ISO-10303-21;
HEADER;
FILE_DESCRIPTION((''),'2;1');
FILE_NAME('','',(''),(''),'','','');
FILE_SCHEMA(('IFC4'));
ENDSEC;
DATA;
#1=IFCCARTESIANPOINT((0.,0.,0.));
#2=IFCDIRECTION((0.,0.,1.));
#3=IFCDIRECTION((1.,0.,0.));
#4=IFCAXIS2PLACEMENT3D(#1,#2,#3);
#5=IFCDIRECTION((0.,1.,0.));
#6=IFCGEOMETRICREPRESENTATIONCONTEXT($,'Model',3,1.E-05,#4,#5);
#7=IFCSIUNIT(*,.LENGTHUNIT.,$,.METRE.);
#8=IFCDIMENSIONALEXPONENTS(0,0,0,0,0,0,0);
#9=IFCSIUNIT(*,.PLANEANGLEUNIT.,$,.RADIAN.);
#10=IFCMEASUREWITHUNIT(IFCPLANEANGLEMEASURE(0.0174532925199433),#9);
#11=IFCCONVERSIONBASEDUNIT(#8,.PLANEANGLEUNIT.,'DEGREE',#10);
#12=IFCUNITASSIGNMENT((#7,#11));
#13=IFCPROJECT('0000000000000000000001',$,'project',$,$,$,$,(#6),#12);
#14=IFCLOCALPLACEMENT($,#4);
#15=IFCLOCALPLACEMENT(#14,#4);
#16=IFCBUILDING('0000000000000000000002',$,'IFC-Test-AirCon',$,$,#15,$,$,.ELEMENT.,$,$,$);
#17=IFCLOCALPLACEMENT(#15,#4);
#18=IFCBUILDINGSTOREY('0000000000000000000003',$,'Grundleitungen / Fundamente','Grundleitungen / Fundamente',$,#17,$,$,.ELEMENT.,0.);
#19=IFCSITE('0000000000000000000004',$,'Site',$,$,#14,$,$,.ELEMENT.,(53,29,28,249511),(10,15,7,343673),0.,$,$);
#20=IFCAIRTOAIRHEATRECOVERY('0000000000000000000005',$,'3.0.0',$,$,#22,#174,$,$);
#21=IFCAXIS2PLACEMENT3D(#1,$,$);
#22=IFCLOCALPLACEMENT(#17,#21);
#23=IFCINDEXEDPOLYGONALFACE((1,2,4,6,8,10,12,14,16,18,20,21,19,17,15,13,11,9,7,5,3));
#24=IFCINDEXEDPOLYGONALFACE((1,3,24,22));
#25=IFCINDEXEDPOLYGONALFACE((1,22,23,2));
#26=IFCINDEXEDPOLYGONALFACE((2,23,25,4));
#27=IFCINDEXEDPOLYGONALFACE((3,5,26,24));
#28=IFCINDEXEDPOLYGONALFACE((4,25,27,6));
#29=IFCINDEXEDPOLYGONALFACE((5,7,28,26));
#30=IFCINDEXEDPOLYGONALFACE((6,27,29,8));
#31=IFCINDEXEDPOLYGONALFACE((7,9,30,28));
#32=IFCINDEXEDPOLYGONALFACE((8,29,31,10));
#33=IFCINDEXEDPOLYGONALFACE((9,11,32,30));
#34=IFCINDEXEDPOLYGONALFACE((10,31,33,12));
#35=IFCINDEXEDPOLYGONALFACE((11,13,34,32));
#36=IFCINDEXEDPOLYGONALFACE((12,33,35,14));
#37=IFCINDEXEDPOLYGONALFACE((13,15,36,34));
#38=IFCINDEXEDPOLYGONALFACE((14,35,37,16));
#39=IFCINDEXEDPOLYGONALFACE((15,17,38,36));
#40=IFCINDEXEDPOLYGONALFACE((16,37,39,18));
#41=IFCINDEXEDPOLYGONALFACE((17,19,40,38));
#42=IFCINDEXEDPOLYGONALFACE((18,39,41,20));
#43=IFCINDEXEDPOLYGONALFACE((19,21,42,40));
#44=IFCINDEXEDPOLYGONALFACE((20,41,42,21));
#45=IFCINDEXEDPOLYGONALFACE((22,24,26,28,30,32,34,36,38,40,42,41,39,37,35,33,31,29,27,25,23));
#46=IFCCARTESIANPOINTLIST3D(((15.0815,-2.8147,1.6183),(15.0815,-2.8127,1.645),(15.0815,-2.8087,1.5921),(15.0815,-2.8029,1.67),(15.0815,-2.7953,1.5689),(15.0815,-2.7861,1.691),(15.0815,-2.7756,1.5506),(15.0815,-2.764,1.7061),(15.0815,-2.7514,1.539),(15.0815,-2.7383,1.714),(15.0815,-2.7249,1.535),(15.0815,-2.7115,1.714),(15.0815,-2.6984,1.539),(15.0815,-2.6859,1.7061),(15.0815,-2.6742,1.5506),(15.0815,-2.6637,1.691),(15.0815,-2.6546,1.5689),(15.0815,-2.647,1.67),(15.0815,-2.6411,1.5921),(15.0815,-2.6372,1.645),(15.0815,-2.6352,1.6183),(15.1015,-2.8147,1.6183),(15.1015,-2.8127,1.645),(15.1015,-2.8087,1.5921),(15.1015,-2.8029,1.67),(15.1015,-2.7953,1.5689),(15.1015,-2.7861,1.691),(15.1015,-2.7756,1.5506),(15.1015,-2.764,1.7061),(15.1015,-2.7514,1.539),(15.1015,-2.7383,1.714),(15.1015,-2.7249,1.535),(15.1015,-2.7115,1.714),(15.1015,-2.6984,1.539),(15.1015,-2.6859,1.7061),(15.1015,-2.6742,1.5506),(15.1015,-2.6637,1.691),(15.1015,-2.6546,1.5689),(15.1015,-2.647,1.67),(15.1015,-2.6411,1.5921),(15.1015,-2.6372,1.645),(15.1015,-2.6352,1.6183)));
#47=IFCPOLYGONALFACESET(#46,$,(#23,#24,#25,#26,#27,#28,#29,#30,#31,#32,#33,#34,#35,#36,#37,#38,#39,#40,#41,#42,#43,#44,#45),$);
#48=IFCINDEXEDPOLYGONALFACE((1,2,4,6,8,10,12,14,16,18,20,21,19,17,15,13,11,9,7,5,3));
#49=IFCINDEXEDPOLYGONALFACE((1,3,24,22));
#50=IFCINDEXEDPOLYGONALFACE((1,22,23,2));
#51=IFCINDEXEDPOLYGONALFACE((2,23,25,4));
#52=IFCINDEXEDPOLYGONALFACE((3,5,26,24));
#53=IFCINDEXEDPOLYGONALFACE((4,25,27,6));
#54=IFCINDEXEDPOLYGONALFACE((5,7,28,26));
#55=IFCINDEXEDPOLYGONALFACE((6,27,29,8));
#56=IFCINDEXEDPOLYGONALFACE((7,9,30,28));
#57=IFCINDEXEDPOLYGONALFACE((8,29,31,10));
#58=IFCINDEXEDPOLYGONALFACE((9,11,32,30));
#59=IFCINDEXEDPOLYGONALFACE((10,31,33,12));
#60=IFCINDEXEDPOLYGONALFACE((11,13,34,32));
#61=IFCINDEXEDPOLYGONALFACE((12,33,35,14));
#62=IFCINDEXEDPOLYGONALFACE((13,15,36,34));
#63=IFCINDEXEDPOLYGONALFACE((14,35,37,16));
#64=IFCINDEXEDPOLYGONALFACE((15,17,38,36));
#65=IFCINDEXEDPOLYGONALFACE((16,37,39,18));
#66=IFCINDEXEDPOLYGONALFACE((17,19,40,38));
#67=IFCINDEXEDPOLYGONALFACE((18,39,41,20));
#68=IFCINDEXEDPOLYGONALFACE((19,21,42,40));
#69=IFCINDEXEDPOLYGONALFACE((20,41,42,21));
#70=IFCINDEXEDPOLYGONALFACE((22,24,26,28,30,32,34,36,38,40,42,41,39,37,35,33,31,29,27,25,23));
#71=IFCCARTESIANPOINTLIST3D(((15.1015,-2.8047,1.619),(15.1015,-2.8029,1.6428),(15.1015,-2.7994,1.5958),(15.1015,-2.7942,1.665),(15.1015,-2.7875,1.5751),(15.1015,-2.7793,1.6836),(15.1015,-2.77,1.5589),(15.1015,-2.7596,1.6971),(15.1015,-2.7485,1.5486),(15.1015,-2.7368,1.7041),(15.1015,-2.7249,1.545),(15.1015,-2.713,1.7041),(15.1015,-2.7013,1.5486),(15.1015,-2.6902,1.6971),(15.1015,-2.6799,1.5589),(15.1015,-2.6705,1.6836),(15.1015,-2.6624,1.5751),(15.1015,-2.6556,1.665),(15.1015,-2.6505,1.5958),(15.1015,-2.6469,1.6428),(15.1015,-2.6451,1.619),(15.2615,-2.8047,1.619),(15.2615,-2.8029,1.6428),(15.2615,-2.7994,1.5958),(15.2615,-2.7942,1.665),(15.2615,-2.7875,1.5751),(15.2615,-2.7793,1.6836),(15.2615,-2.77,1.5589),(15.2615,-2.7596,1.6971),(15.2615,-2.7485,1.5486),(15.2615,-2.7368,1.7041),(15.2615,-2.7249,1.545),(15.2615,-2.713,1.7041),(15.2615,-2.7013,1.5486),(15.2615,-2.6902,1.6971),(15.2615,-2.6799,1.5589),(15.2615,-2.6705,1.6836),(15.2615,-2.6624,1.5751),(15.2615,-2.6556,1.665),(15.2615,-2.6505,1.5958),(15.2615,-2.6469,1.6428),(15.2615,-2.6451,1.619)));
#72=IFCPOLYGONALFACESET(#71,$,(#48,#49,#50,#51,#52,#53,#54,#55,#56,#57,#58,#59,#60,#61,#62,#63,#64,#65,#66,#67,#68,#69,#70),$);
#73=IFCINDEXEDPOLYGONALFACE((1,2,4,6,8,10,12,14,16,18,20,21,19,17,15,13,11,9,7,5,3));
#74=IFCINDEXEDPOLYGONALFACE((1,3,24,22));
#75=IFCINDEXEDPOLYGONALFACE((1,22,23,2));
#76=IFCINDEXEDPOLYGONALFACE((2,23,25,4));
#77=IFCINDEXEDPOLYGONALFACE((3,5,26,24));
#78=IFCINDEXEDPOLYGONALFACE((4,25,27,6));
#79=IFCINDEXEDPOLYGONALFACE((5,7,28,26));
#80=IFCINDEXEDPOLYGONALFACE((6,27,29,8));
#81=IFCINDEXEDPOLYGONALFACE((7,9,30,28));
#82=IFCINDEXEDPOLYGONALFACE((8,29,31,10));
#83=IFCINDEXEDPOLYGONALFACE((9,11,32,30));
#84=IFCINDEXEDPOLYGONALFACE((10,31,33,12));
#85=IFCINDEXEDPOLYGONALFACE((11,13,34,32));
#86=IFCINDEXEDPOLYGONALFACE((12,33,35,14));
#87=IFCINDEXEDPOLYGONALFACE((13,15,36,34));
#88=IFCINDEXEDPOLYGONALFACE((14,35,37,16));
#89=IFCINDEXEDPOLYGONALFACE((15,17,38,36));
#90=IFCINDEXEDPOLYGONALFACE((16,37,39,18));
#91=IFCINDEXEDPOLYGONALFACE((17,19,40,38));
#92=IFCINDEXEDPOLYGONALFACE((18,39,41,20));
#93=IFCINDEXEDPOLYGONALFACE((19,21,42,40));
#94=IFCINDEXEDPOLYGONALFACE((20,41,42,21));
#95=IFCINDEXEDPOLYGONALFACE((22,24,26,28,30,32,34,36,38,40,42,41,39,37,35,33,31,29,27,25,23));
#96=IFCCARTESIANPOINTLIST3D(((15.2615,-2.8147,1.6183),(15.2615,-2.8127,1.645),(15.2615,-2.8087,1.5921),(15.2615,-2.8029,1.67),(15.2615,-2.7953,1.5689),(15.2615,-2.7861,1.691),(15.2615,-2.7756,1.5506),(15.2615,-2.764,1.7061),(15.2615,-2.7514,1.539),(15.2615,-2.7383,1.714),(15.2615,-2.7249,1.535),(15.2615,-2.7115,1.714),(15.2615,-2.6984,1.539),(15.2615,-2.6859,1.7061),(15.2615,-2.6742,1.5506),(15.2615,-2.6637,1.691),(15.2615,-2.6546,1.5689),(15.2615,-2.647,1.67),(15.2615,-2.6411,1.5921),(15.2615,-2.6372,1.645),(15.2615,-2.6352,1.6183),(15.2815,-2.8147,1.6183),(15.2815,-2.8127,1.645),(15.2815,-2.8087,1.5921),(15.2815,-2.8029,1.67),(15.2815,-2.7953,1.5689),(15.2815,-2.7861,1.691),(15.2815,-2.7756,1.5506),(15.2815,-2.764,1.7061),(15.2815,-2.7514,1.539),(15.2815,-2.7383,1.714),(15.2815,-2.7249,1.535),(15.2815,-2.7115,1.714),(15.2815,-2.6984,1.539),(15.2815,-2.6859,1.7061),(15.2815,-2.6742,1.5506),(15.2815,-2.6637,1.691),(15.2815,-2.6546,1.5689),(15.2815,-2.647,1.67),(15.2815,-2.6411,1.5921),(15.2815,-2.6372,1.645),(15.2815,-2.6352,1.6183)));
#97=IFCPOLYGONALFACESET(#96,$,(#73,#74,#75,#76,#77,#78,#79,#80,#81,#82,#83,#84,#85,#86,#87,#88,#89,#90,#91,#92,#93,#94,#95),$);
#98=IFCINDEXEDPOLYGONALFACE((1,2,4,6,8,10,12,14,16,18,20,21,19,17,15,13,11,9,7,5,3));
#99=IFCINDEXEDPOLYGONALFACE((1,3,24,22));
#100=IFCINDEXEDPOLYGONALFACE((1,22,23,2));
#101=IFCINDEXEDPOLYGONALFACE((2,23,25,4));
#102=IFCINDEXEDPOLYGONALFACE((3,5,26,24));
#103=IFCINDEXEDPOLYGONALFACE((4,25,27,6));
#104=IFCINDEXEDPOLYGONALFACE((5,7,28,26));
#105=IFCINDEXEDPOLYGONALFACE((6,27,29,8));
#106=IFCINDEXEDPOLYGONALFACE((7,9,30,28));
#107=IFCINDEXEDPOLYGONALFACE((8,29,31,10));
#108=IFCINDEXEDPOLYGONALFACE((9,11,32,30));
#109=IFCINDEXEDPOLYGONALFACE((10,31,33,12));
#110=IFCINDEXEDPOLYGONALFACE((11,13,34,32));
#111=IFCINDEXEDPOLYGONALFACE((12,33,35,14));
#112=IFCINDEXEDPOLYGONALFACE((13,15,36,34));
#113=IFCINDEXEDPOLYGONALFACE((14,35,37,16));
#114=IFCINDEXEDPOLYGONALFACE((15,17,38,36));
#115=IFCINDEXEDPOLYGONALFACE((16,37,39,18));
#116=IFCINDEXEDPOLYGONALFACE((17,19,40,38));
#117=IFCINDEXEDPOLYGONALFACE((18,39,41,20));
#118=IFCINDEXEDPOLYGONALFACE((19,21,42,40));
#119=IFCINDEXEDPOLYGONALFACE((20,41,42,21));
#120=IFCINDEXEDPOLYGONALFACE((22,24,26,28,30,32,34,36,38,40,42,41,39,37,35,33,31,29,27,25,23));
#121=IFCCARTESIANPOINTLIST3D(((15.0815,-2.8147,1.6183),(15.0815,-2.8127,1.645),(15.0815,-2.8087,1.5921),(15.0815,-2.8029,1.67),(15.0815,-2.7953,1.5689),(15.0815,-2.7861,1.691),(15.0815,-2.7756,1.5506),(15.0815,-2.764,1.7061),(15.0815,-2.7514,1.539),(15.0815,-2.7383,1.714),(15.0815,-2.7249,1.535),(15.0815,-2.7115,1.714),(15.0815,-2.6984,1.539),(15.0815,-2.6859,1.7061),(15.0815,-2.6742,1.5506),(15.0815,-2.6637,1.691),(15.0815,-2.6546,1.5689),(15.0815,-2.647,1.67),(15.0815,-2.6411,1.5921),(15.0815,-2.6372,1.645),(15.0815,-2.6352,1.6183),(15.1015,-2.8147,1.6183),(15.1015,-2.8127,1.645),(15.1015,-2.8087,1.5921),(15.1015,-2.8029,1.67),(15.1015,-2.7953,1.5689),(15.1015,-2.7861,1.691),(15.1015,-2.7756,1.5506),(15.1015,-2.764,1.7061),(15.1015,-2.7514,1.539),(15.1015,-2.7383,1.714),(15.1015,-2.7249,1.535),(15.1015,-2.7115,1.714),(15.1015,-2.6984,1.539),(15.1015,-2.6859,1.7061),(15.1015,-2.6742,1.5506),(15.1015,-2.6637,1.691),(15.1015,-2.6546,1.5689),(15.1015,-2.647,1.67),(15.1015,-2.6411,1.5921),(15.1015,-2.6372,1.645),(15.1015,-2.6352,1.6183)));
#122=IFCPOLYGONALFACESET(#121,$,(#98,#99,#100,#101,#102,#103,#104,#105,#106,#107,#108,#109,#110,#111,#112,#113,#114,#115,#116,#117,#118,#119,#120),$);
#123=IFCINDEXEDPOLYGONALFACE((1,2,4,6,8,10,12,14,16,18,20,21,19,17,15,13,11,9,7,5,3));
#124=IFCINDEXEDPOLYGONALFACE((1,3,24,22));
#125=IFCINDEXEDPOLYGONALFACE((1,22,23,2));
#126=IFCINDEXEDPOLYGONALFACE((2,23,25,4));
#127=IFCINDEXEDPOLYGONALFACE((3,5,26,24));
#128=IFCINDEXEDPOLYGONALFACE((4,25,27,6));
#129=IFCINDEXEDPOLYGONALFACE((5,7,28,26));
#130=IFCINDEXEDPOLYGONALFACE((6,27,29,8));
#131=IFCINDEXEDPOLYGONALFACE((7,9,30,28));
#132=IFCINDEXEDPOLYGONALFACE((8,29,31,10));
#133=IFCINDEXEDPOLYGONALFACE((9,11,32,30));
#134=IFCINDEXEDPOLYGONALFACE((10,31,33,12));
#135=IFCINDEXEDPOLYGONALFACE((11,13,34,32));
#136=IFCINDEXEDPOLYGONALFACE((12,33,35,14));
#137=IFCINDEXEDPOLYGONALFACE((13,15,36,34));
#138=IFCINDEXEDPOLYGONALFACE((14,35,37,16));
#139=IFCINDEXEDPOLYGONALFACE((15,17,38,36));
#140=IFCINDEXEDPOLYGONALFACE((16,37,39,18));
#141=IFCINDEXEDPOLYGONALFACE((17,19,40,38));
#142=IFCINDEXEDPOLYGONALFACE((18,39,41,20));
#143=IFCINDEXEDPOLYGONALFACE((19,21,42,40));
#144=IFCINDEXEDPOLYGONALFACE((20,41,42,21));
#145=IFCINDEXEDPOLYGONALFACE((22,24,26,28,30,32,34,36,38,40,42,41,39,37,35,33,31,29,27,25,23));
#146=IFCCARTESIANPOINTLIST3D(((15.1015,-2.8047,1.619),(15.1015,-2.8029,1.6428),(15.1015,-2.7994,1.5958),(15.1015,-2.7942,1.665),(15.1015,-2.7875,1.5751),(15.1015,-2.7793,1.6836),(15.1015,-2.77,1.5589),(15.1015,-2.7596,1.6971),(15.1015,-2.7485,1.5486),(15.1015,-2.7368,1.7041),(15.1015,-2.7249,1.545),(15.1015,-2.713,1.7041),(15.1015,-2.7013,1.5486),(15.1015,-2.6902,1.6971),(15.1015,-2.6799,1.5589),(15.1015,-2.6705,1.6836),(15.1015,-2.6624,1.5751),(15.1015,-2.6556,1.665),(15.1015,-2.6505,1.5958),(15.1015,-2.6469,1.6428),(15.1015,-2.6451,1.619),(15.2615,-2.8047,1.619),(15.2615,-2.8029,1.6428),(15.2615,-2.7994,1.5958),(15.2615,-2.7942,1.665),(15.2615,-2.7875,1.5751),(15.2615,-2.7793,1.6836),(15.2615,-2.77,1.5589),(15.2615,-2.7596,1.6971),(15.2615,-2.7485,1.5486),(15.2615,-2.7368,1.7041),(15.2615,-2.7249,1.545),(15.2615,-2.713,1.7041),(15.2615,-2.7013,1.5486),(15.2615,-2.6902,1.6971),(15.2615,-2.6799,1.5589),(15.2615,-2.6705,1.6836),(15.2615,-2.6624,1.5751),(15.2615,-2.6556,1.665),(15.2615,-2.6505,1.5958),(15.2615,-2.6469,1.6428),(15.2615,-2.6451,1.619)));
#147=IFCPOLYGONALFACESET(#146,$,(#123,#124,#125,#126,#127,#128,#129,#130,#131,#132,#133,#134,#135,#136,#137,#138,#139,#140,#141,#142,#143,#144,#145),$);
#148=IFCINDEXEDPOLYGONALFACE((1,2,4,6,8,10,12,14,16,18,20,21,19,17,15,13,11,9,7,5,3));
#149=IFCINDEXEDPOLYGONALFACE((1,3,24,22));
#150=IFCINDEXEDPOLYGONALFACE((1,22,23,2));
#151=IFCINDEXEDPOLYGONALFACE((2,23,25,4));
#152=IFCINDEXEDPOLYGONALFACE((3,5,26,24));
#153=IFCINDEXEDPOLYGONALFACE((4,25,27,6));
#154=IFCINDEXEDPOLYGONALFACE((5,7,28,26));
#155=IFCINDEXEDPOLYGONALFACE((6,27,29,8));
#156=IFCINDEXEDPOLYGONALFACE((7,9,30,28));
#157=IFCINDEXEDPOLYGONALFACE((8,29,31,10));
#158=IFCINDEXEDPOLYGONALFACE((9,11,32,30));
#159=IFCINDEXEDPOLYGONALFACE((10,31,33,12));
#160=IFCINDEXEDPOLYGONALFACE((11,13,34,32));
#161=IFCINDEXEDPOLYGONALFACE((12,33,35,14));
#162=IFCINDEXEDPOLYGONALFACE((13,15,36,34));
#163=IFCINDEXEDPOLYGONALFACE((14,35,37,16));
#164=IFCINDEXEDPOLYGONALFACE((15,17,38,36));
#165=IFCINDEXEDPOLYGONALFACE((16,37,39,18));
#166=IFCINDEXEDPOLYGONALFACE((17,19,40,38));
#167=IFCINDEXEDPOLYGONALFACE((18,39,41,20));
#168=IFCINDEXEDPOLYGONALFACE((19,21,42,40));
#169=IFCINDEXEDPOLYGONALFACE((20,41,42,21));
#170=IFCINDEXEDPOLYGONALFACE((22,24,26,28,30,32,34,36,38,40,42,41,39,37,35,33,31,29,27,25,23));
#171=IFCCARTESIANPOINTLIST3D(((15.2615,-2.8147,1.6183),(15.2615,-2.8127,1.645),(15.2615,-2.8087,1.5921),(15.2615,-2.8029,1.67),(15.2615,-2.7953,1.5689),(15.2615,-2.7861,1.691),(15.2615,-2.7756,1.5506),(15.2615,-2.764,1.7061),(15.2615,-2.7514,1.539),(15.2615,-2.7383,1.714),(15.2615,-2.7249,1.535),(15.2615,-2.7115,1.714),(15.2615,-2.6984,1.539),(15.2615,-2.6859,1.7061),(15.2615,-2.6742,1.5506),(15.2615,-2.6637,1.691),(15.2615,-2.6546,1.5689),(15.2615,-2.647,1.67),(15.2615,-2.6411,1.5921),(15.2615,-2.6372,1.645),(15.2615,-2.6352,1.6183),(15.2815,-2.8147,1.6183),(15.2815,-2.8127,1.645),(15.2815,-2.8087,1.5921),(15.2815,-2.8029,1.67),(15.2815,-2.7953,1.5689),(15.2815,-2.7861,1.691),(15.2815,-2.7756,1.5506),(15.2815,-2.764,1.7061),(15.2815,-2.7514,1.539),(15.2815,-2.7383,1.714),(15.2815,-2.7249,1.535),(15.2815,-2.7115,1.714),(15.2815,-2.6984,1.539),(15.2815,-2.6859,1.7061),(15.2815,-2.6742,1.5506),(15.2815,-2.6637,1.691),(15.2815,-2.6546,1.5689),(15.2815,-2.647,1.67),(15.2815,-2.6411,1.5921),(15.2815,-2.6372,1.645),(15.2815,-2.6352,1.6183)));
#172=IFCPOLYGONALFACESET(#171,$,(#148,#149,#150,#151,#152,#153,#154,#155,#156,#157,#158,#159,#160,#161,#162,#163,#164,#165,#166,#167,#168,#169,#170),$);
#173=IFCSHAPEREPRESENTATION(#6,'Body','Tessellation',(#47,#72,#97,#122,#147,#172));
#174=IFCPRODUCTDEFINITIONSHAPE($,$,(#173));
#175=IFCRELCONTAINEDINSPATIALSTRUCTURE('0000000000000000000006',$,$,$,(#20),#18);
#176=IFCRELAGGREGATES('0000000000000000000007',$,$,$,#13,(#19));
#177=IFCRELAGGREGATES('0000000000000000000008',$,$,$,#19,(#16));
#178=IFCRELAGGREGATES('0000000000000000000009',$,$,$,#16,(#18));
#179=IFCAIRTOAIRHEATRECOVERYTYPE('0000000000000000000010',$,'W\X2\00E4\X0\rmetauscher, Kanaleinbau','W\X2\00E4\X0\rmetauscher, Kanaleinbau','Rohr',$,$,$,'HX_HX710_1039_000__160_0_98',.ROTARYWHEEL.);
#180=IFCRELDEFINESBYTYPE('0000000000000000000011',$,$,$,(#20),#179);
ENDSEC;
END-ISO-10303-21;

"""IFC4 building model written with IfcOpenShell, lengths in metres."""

from ifc_helpers import new_model, entity, si_unit, converted_unit, direction, frame, origin_with_axes, origin_2d_with_axis, place, context, subcontext, project, spatial, circle, extrude, source, transform, mapped, type_object, element, save


model = new_model("IFC4")

# Units and contexts
model_context = context("Model", 3, precision=1e-05, world=origin_with_axes(), true_north=direction((0.0, 1.0, 0.0)))
body_context = subcontext(model_context, "Body", "Model", "MODEL_VIEW")
ifc_project = project(units=[si_unit("LENGTHUNIT", "METRE"), converted_unit("PLANEANGLEUNIT", "DEGREE", entity("IfcPlaneAngleMeasure", 0.0174532925199433), si_unit("PLANEANGLEUNIT", "RADIAN"), dimensions=[0, 0, 0, 0, 0, 0, 0])], contexts=[model_context])

# Site, building, storey
site_placement = place(None, origin_with_axes())
site = spatial("IfcSite", under=ifc_project, at=site_placement, Name="Site", CompositionType="ELEMENT", RefLatitude=(53, 29, 28, 249511), RefLongitude=(10, 15, 7, 343673), RefElevation=0.0)
building_placement = place(site_placement, origin_with_axes())
building = spatial("IfcBuilding", under=site, at=building_placement, Name="IFC-Test-AirCon", CompositionType="ELEMENT")
storey_placement = place(building_placement, origin_with_axes())
storey = spatial("IfcBuildingStorey", under=building, at=storey_placement, Name="Grundleitungen / Fundamente", Description="Grundleitungen / Fundamente", CompositionType="ELEMENT", Elevation=0.0)

# Air to air heat recovery
air_to_air_heat_recovery_type = type_object("IfcAirToAirHeatRecoveryType", Name="Wärmetauscher, Kanaleinbau", Description="Wärmetauscher, Kanaleinbau", ApplicableOccurrence="Rohr", ElementType="HX_HX710_1039_000__160_0_98", PredefinedType="ROTARYWHEEL")
shared_shape_1 = source(origin_with_axes(), body_context, "Body", "SweptSolid", [
    extrude(circle(Radius=0.09, at=origin_2d_with_axis()), frame((-0.1, 0.0, 0.0), z_axis=(1.0, 0.0, 0.0), x_axis=(0.0, 0.0, -1.0)), (0.0, 0.0, 1.0), 0.02),
    extrude(circle(Radius=0.08, at=origin_2d_with_axis()), frame((-0.08, 0.0, 0.0), z_axis=(1.0, 0.0, 0.0), x_axis=(0.0, 0.0, -1.0)), (0.0, 0.0, 1.0), 0.16),
    extrude(circle(Radius=0.09, at=origin_2d_with_axis()), frame((0.08, 0.0, 0.0), z_axis=(1.0, 0.0, 0.0), x_axis=(0.0, 0.0, -1.0)), (0.0, 0.0, 1.0), 0.02),
    extrude(circle(Radius=0.09, at=origin_2d_with_axis()), frame((-0.1, 0.0, 0.0), z_axis=(1.0, 0.0, 0.0), x_axis=(0.0, 0.0, -1.0)), (0.0, 0.0, 1.0), 0.02),
    extrude(circle(Radius=0.08, at=origin_2d_with_axis()), frame((-0.08, 0.0, 0.0), z_axis=(1.0, 0.0, 0.0), x_axis=(0.0, 0.0, -1.0)), (0.0, 0.0, 1.0), 0.16),
    extrude(circle(Radius=0.09, at=origin_2d_with_axis()), frame((0.08, 0.0, 0.0), z_axis=(1.0, 0.0, 0.0), x_axis=(0.0, 0.0, -1.0)), (0.0, 0.0, 1.0), 0.02),
])
air_to_air_heat_recovery_placement = place(storey_placement, frame((15.1815, -2.7249, 1.625), z_axis=(0.0, 0.0, 1.0), x_axis=(1.0, 0.0, 0.0)))
element("IfcAirToAirHeatRecovery", 1, at=air_to_air_heat_recovery_placement, inside=storey, type_object=air_to_air_heat_recovery_type, Name="3.0.0", context=model_context, shape_type="MappedRepresentation", body=[
    mapped(shared_shape_1, transform((0.0, 0.0, 0.0), scale=1.0)),
])

save(model, "model.ifc")
